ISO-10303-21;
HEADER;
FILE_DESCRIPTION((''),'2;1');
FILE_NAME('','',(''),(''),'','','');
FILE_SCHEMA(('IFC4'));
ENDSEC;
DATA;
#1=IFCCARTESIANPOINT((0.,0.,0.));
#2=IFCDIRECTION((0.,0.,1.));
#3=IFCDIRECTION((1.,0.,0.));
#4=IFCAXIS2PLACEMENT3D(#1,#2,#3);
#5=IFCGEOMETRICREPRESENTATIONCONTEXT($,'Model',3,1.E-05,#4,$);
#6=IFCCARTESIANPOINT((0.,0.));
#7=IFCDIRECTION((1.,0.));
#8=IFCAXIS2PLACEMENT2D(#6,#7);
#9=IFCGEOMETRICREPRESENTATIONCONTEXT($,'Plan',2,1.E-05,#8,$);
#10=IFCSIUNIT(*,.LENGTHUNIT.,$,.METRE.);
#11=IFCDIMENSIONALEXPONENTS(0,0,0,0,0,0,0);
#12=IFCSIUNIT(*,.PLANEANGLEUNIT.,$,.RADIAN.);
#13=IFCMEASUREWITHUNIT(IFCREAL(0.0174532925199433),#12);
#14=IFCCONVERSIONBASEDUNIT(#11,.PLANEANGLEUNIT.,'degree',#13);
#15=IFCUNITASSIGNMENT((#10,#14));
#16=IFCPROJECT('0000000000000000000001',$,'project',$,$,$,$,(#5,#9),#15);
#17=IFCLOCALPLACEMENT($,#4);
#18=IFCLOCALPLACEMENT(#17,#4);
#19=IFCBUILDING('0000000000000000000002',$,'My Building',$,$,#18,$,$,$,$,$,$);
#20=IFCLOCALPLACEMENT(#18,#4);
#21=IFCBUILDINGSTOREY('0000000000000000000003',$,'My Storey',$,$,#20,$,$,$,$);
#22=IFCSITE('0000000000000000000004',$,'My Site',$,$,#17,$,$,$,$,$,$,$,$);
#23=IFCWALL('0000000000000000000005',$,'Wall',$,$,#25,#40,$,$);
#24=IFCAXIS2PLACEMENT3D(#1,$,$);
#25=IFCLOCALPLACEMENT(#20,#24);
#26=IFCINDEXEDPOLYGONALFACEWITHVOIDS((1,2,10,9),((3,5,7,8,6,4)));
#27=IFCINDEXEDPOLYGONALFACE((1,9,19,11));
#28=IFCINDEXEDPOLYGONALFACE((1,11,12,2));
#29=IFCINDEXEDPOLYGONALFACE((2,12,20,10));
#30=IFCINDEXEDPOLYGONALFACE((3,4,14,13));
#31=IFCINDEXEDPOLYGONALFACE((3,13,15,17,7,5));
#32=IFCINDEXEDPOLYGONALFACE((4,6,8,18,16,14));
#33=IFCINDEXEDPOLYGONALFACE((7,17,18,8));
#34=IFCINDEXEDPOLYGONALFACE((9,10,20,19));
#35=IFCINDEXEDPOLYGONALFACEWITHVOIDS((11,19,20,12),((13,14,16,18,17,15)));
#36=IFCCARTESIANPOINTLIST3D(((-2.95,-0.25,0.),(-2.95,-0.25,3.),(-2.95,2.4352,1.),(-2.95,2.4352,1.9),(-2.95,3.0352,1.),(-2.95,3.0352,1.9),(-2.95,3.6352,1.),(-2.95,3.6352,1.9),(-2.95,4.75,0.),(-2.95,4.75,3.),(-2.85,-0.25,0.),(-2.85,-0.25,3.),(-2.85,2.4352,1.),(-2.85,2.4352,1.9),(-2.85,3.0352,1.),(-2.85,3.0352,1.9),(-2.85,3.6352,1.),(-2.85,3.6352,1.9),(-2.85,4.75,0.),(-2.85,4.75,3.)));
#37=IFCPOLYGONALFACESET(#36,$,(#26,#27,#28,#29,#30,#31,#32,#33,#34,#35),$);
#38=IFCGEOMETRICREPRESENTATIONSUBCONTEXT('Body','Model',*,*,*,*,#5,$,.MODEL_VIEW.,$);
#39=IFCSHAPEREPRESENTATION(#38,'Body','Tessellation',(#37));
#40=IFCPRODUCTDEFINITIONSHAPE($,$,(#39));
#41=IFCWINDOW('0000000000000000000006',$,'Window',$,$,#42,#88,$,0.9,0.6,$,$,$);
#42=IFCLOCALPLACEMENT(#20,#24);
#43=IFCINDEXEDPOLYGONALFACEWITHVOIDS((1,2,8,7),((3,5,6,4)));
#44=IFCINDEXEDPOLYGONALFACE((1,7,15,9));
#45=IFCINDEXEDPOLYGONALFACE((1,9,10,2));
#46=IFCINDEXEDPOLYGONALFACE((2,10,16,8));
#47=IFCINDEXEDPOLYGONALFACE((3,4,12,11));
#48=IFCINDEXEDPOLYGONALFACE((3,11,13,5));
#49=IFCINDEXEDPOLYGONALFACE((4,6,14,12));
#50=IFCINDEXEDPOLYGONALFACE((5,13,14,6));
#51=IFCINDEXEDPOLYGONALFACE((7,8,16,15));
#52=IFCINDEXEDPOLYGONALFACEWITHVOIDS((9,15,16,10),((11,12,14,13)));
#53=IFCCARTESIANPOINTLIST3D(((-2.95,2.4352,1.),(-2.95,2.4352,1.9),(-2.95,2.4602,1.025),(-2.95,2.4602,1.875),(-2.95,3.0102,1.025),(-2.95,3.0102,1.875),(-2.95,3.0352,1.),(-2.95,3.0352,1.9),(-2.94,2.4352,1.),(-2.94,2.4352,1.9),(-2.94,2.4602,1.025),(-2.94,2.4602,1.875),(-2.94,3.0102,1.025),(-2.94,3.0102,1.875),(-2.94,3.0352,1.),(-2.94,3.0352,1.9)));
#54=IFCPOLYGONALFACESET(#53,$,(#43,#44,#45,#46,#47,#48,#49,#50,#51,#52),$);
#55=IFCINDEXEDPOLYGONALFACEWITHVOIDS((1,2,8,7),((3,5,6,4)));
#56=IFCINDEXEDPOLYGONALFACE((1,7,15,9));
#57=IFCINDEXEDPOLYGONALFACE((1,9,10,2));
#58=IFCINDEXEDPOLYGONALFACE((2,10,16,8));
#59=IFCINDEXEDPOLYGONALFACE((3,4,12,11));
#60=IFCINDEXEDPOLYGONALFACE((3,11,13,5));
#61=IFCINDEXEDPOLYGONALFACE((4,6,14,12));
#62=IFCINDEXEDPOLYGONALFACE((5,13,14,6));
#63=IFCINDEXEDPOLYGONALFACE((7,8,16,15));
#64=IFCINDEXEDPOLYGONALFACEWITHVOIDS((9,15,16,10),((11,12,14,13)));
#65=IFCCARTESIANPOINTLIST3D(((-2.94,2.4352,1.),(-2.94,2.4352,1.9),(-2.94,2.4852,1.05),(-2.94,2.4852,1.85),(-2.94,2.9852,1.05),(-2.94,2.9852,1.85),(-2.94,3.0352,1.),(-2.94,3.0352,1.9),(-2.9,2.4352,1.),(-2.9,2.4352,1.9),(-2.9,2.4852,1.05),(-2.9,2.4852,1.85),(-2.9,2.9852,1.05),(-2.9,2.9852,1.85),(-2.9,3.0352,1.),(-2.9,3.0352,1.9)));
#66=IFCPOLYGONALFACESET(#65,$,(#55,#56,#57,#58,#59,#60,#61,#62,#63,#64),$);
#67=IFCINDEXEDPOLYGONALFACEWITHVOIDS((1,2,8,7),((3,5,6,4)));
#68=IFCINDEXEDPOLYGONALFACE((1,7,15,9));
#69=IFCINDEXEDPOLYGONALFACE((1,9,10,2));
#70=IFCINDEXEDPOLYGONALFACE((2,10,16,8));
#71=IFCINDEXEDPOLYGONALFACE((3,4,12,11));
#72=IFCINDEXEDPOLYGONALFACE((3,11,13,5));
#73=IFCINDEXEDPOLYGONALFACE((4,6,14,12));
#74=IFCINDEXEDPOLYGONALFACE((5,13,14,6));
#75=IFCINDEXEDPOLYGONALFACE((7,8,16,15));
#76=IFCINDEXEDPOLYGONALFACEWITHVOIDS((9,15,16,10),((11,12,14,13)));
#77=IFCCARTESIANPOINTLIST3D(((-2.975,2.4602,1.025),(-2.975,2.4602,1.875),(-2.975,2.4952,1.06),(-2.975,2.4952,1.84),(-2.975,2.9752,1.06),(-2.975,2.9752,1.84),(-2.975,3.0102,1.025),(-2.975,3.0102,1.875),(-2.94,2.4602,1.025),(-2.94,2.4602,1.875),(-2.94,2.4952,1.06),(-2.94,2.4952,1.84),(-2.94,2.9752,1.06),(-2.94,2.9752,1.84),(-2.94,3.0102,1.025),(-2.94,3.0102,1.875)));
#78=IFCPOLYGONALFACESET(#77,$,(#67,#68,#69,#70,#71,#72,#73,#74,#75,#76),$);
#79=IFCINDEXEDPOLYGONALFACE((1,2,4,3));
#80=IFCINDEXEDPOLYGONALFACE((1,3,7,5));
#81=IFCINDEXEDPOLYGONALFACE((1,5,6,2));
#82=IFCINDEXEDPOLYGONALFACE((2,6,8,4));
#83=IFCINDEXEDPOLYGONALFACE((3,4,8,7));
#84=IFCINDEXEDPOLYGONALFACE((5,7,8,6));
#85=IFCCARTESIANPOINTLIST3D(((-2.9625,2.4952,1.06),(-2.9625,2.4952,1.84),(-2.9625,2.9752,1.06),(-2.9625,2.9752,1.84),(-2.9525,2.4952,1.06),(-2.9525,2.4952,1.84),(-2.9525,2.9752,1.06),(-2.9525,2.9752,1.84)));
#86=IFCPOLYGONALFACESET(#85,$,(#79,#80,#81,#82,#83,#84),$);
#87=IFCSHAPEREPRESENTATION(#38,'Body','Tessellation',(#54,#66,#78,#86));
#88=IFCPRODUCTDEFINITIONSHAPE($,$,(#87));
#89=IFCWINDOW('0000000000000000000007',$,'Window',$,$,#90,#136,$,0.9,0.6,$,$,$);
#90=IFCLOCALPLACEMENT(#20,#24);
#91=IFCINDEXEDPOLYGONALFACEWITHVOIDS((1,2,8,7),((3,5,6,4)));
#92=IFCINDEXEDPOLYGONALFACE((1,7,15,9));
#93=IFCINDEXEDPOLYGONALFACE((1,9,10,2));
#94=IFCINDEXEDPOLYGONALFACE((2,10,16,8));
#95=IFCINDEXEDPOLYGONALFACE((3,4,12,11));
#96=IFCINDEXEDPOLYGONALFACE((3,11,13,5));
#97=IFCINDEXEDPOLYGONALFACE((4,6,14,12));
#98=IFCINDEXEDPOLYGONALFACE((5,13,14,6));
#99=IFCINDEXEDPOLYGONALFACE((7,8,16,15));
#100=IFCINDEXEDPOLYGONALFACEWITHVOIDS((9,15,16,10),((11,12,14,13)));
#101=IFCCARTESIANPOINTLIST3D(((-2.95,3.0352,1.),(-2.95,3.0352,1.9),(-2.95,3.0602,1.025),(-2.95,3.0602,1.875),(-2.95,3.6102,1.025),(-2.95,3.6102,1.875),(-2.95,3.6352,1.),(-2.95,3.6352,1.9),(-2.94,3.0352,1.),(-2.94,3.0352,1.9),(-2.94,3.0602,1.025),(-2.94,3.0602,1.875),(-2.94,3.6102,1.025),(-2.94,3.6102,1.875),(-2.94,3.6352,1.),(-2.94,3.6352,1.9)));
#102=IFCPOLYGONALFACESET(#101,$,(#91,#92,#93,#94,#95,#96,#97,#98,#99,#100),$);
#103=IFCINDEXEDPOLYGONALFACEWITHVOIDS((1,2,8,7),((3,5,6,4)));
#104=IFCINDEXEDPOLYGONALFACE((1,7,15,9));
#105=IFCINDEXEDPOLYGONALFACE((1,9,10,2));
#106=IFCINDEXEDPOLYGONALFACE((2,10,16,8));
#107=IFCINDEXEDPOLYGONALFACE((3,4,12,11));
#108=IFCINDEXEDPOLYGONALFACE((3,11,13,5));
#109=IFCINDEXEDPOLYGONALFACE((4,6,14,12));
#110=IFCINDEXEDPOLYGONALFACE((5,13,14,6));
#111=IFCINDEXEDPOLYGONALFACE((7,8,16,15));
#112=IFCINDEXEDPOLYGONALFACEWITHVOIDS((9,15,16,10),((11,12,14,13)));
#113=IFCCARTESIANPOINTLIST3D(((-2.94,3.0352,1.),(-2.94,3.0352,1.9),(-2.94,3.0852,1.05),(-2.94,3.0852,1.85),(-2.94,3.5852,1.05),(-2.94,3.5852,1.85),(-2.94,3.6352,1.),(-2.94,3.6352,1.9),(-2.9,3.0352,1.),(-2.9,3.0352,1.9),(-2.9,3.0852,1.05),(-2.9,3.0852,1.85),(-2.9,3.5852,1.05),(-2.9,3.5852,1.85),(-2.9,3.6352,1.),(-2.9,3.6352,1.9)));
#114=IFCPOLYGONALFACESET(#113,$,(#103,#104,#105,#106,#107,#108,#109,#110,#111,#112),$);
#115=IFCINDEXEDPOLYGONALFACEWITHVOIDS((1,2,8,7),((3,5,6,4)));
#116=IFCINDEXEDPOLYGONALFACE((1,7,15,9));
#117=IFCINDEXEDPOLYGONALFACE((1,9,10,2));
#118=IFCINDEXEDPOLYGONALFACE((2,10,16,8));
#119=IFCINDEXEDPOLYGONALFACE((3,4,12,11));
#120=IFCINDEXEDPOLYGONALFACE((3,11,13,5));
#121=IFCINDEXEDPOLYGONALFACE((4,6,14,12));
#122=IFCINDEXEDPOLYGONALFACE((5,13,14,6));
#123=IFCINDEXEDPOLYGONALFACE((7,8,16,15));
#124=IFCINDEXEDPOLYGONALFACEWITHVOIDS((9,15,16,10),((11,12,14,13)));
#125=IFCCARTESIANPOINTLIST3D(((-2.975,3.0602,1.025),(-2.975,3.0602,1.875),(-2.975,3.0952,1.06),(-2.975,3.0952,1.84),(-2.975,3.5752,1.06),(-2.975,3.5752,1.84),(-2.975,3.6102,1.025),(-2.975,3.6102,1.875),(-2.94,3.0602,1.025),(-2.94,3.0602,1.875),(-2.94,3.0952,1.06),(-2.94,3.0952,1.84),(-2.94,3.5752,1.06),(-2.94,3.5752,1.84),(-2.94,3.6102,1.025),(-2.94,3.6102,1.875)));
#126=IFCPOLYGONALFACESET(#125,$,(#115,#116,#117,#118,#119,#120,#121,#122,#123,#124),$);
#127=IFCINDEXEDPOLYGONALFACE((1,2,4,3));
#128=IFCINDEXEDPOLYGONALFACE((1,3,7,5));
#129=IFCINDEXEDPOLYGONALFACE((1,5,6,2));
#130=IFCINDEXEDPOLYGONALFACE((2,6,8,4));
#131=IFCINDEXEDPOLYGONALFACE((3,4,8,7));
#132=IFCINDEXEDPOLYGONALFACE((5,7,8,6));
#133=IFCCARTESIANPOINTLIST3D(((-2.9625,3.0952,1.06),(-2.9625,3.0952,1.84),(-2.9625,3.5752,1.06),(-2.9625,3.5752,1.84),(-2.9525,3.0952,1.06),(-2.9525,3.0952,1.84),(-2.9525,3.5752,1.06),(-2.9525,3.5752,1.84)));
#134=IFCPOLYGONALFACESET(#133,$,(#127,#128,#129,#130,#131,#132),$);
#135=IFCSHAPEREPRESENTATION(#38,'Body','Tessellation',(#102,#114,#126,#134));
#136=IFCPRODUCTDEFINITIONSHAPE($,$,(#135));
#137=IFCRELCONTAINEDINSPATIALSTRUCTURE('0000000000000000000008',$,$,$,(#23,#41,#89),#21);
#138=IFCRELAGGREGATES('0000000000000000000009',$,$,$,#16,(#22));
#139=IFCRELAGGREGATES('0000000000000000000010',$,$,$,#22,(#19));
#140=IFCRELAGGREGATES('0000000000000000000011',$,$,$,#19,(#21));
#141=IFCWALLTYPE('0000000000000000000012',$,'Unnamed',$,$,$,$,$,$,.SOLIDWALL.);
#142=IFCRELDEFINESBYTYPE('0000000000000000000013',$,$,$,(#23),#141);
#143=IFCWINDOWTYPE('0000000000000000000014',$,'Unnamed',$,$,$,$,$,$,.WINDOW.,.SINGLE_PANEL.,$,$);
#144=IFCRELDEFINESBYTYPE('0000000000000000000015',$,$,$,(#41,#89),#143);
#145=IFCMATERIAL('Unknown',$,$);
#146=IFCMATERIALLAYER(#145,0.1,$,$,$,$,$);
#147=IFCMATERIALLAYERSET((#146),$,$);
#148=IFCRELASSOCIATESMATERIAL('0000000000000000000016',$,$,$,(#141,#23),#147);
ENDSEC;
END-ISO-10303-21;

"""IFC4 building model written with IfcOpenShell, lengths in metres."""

from ifc_helpers import new_model, entity, si_unit, converted_unit, frame, origin_with_axes, origin_2d_with_axis, place, context, subcontext, project, spatial, line, indexed_curve, outline, extrude, shape, source, transform, mapped, material, layer, layer_set, layer_usage, type_object, type_shapes, element, fill, save


model = new_model("IFC4")

# Units and contexts
model_context = context("Model", 3, precision=1e-05, world=origin_with_axes())
plan_context = context("Plan", 2, precision=1e-05, world=origin_2d_with_axis())
body_context_1 = subcontext(model_context, "Body", "Model", "MODEL_VIEW")
body_context_2 = subcontext(plan_context, "Body", "Plan", "PLAN_VIEW")
ifc_project = project(units=[si_unit("LENGTHUNIT", "METRE"), converted_unit("PLANEANGLEUNIT", "degree", entity("IfcReal", 0.0174532925199433), si_unit("PLANEANGLEUNIT", "RADIAN"), dimensions=[0, 0, 0, 0, 0, 0, 0])], contexts=[model_context, plan_context])

# Site, building, storey
site_placement = place(None, origin_with_axes())
site = spatial("IfcSite", under=ifc_project, at=site_placement, Name="My Site")
building_placement = place(site_placement, origin_with_axes())
building = spatial("IfcBuilding", under=site, at=building_placement, Name="My Building")
storey_placement = place(building_placement, origin_with_axes())
storey = spatial("IfcBuildingStorey", under=building, at=storey_placement, Name="My Storey")

# Shared definitions
ifc_material = material(Name="Unknown")

# Shared definitions
ifc_layer_1 = layer(ifc_material, 0.1)
ifc_layer_set_1 = layer_set([ifc_layer_1])
wall_type = type_object("IfcWallType", Name="Unnamed", PredefinedType="SOLIDWALL", material=ifc_layer_set_1)
shared_shape_1 = source(origin_with_axes(), body_context_1, "Body", "SweptSolid", [
    extrude(outline(indexed_curve([(0.0, 0.0), (0.6, 0.0), (0.6, 0.9), (0.0, 0.9)], segments=[line(1, 2, 3, 4, 1)])), frame((0.0, -0.6, 0.0), z_axis=(0.0, -1.0, 0.0), x_axis=(1.0, 0.0, 0.0)), (0.0, 0.0, -1.0), 1.2),
])
window_type = type_object("IfcWindowType", Name="Unnamed", PartitioningType="SINGLE_PANEL", PredefinedType="WINDOW")
shared_shape_2 = source(origin_with_axes(), body_context_1, "Body", "SweptSolid", [
    extrude(outline(indexed_curve([(0.0, 0.0), (0.6, 0.0), (0.6, 0.9), (0.0, 0.9)], segments=[line(1, 2, 3, 4, 1)]), holes=[indexed_curve([(0.025, 0.025), (0.575, 0.025), (0.575, 0.875), (0.025, 0.875)], segments=[line(1, 2, 3, 4, 1)])]), frame((0.0, 0.09, 0.0), z_axis=(0.0, -1.0, 0.0), x_axis=(1.0, 0.0, 0.0)), (0.0, 0.0, -1.0), 0.01),
    extrude(outline(indexed_curve([(0.0, 0.0), (0.6, 0.0), (0.6, 0.9), (0.0, 0.9)], segments=[line(1, 2, 3, 4, 1)]), holes=[indexed_curve([(0.05, 0.05), (0.55, 0.05), (0.55, 0.85), (0.05, 0.85)], segments=[line(1, 2, 3, 4, 1)])]), frame((0.0, 0.05, 0.0), z_axis=(0.0, -1.0, 0.0), x_axis=(1.0, 0.0, 0.0)), (0.0, 0.0, -1.0), 0.04),
    extrude(outline(indexed_curve([(0.0, 0.0), (0.55, 0.0), (0.55, 0.85), (0.0, 0.85)], segments=[line(1, 2, 3, 4, 1)]), holes=[indexed_curve([(0.035, 0.035), (0.515, 0.035), (0.515, 0.815), (0.035, 0.815)], segments=[line(1, 2, 3, 4, 1)])]), frame((0.025, 0.09, 0.025), z_axis=(0.0, -1.0, 0.0), x_axis=(1.0, 0.0, 0.0)), (0.0, 0.0, -1.0), 0.035),
    extrude(outline(indexed_curve([(0.035, 0.035), (0.515, 0.035), (0.515, 0.815), (0.035, 0.815)], segments=[line(1, 2, 3, 4, 1)])), frame((0.025, 0.1025, 0.025), z_axis=(0.0, -1.0, 0.0), x_axis=(1.0, 0.0, 0.0)), (0.0, 0.0, -1.0), 0.01),
])
shared_shape_3 = source(origin_with_axes(), body_context_2, "Body", "Curve2D", [
    entity("IfcIndexedPolyCurve", entity("IfcCartesianPointList2D", [[0.05, 0.05], [0.55, 0.05]])),
    entity("IfcIndexedPolyCurve", entity("IfcCartesianPointList2D", [[0.0, 0.1], [0.025, 0.1], [0.025, 0.09], [0.05, 0.09], [0.05, 0.05], [0.0, 0.05]]), [entity("IfcLineIndex", [1, 2, 3, 4, 5, 6, 1])]),
    entity("IfcIndexedPolyCurve", entity("IfcCartesianPointList2D", [[0.6, 0.1], [0.575, 0.1], [0.575, 0.09], [0.55, 0.09], [0.55, 0.05], [0.6, 0.05]]), [entity("IfcLineIndex", [1, 2, 3, 4, 5, 6, 1])]),
    entity("IfcIndexedPolyCurve", entity("IfcCartesianPointList2D", [[0.025, 0.09], [0.06, 0.09], [0.06, 0.125], [0.025, 0.125]]), [entity("IfcLineIndex", [1, 2, 3, 4, 1])]),
    entity("IfcIndexedPolyCurve", entity("IfcCartesianPointList2D", [[0.575, 0.09], [0.54, 0.09], [0.54, 0.125], [0.575, 0.125]]), [entity("IfcLineIndex", [1, 2, 3, 4, 1])]),
    entity("IfcIndexedPolyCurve", entity("IfcCartesianPointList2D", [[0.06, 0.09], [0.54, 0.09]])),
    entity("IfcIndexedPolyCurve", entity("IfcCartesianPointList2D", [[0.06, 0.125], [0.54, 0.125]])),
    entity("IfcIndexedPolyCurve", entity("IfcCartesianPointList2D", [[0.06, 0.1075], [0.54, 0.1075]])),
])
type_shapes(window_type, [shared_shape_2, shared_shape_3])

# Wall, openings, windows
ifc_layer_usage_1 = layer_usage(ifc_layer_set_1, "AXIS2", "POSITIVE", 0.0)
wall_1_placement = place(storey_placement, frame((-2.85, -0.25, 0.0), z_axis=(0.0, 0.0, 1.0), x_axis=(0.0, 1.0, 0.0)))
wall_1 = element("IfcWall", 1, at=wall_1_placement, inside=storey, type_object=wall_type, material=ifc_layer_usage_1, Name="Wall", context=body_context_1, shape_type="SweptSolid", body=[
    extrude(outline(indexed_curve([(0.0, 0.0), (0.0, 0.1), (5.0, 0.1), (5.0, 0.0)], segments=[line(1, 2, 3, 4, 1)])), origin_with_axes(), (0.0, 0.0, 1.0), 3.0),
])
opening_1_placement = place(wall_1_placement, frame((2.6852, 0.0, 1.0), z_axis=(0.0, 0.0, 1.0), x_axis=(1.0, 0.0, 0.0)))
opening_1 = element("IfcOpeningElement", 2, at=opening_1_placement, cuts=wall_1, PredefinedType="OPENING", context=body_context_1, shape_type="MappedRepresentation", body=[
    mapped(shared_shape_1, transform((0.0, 0.0, 0.0), x_axis=(1.0, 0.0, 0.0), y_axis=(0.0, 1.0, 0.0), z_axis=(0.0, 0.0, 1.0), scale=1.0)),
])
opening_2_placement = place(wall_1_placement, frame((3.2852, 0.0, 1.0), z_axis=(0.0, 0.0, 1.0), x_axis=(1.0, 0.0, 0.0)))
opening_2 = element("IfcOpeningElement", 3, at=opening_2_placement, cuts=wall_1, PredefinedType="OPENING", context=body_context_1, shape_type="MappedRepresentation", body=[
    mapped(shared_shape_1, transform((0.0, 0.0, 0.0), x_axis=(1.0, 0.0, 0.0), y_axis=(0.0, 1.0, 0.0), z_axis=(0.0, 0.0, 1.0), scale=1.0)),
])
window_1_placement = place(opening_1_placement, frame((0.0, 0.0, 0.0), z_axis=(0.0, 0.0, 1.0), x_axis=(1.0, 0.0, 0.0)))
window_1 = element("IfcWindow", 4, at=window_1_placement, inside=storey, type_object=window_type, Name="Window", OverallHeight=0.9, OverallWidth=0.6, shapes=[
    shape(body_context_1, "Body", "MappedRepresentation", [mapped(shared_shape_2, transform((0.0, 0.0, 0.0), x_axis=(1.0, 0.0, 0.0), y_axis=(0.0, 1.0, 0.0), z_axis=(0.0, 0.0, 1.0), scale=1.0))]),
    shape(body_context_2, "Body", "MappedRepresentation", [mapped(shared_shape_3, transform((0.0, 0.0, 0.0), x_axis=(1.0, 0.0, 0.0), y_axis=(0.0, 1.0, 0.0), z_axis=(0.0, 0.0, 1.0), scale=1.0))]),
])
fill(opening_1, window_1)
window_2_placement = place(opening_2_placement, frame((0.0, 0.0, 0.0), z_axis=(0.0, 0.0, 1.0), x_axis=(1.0, 0.0, 0.0)))
window_2 = element("IfcWindow", 5, at=window_2_placement, inside=storey, type_object=window_type, Name="Window", OverallHeight=0.9, OverallWidth=0.6, shapes=[
    shape(body_context_1, "Body", "MappedRepresentation", [mapped(shared_shape_2, transform((0.0, 0.0, 0.0), x_axis=(1.0, 0.0, 0.0), y_axis=(0.0, 1.0, 0.0), z_axis=(0.0, 0.0, 1.0), scale=1.0))]),
    shape(body_context_2, "Body", "MappedRepresentation", [mapped(shared_shape_3, transform((0.0, 0.0, 0.0), x_axis=(1.0, 0.0, 0.0), y_axis=(0.0, 1.0, 0.0), z_axis=(0.0, 0.0, 1.0), scale=1.0))]),
])
fill(opening_2, window_2)

save(model, "model.ifc")
